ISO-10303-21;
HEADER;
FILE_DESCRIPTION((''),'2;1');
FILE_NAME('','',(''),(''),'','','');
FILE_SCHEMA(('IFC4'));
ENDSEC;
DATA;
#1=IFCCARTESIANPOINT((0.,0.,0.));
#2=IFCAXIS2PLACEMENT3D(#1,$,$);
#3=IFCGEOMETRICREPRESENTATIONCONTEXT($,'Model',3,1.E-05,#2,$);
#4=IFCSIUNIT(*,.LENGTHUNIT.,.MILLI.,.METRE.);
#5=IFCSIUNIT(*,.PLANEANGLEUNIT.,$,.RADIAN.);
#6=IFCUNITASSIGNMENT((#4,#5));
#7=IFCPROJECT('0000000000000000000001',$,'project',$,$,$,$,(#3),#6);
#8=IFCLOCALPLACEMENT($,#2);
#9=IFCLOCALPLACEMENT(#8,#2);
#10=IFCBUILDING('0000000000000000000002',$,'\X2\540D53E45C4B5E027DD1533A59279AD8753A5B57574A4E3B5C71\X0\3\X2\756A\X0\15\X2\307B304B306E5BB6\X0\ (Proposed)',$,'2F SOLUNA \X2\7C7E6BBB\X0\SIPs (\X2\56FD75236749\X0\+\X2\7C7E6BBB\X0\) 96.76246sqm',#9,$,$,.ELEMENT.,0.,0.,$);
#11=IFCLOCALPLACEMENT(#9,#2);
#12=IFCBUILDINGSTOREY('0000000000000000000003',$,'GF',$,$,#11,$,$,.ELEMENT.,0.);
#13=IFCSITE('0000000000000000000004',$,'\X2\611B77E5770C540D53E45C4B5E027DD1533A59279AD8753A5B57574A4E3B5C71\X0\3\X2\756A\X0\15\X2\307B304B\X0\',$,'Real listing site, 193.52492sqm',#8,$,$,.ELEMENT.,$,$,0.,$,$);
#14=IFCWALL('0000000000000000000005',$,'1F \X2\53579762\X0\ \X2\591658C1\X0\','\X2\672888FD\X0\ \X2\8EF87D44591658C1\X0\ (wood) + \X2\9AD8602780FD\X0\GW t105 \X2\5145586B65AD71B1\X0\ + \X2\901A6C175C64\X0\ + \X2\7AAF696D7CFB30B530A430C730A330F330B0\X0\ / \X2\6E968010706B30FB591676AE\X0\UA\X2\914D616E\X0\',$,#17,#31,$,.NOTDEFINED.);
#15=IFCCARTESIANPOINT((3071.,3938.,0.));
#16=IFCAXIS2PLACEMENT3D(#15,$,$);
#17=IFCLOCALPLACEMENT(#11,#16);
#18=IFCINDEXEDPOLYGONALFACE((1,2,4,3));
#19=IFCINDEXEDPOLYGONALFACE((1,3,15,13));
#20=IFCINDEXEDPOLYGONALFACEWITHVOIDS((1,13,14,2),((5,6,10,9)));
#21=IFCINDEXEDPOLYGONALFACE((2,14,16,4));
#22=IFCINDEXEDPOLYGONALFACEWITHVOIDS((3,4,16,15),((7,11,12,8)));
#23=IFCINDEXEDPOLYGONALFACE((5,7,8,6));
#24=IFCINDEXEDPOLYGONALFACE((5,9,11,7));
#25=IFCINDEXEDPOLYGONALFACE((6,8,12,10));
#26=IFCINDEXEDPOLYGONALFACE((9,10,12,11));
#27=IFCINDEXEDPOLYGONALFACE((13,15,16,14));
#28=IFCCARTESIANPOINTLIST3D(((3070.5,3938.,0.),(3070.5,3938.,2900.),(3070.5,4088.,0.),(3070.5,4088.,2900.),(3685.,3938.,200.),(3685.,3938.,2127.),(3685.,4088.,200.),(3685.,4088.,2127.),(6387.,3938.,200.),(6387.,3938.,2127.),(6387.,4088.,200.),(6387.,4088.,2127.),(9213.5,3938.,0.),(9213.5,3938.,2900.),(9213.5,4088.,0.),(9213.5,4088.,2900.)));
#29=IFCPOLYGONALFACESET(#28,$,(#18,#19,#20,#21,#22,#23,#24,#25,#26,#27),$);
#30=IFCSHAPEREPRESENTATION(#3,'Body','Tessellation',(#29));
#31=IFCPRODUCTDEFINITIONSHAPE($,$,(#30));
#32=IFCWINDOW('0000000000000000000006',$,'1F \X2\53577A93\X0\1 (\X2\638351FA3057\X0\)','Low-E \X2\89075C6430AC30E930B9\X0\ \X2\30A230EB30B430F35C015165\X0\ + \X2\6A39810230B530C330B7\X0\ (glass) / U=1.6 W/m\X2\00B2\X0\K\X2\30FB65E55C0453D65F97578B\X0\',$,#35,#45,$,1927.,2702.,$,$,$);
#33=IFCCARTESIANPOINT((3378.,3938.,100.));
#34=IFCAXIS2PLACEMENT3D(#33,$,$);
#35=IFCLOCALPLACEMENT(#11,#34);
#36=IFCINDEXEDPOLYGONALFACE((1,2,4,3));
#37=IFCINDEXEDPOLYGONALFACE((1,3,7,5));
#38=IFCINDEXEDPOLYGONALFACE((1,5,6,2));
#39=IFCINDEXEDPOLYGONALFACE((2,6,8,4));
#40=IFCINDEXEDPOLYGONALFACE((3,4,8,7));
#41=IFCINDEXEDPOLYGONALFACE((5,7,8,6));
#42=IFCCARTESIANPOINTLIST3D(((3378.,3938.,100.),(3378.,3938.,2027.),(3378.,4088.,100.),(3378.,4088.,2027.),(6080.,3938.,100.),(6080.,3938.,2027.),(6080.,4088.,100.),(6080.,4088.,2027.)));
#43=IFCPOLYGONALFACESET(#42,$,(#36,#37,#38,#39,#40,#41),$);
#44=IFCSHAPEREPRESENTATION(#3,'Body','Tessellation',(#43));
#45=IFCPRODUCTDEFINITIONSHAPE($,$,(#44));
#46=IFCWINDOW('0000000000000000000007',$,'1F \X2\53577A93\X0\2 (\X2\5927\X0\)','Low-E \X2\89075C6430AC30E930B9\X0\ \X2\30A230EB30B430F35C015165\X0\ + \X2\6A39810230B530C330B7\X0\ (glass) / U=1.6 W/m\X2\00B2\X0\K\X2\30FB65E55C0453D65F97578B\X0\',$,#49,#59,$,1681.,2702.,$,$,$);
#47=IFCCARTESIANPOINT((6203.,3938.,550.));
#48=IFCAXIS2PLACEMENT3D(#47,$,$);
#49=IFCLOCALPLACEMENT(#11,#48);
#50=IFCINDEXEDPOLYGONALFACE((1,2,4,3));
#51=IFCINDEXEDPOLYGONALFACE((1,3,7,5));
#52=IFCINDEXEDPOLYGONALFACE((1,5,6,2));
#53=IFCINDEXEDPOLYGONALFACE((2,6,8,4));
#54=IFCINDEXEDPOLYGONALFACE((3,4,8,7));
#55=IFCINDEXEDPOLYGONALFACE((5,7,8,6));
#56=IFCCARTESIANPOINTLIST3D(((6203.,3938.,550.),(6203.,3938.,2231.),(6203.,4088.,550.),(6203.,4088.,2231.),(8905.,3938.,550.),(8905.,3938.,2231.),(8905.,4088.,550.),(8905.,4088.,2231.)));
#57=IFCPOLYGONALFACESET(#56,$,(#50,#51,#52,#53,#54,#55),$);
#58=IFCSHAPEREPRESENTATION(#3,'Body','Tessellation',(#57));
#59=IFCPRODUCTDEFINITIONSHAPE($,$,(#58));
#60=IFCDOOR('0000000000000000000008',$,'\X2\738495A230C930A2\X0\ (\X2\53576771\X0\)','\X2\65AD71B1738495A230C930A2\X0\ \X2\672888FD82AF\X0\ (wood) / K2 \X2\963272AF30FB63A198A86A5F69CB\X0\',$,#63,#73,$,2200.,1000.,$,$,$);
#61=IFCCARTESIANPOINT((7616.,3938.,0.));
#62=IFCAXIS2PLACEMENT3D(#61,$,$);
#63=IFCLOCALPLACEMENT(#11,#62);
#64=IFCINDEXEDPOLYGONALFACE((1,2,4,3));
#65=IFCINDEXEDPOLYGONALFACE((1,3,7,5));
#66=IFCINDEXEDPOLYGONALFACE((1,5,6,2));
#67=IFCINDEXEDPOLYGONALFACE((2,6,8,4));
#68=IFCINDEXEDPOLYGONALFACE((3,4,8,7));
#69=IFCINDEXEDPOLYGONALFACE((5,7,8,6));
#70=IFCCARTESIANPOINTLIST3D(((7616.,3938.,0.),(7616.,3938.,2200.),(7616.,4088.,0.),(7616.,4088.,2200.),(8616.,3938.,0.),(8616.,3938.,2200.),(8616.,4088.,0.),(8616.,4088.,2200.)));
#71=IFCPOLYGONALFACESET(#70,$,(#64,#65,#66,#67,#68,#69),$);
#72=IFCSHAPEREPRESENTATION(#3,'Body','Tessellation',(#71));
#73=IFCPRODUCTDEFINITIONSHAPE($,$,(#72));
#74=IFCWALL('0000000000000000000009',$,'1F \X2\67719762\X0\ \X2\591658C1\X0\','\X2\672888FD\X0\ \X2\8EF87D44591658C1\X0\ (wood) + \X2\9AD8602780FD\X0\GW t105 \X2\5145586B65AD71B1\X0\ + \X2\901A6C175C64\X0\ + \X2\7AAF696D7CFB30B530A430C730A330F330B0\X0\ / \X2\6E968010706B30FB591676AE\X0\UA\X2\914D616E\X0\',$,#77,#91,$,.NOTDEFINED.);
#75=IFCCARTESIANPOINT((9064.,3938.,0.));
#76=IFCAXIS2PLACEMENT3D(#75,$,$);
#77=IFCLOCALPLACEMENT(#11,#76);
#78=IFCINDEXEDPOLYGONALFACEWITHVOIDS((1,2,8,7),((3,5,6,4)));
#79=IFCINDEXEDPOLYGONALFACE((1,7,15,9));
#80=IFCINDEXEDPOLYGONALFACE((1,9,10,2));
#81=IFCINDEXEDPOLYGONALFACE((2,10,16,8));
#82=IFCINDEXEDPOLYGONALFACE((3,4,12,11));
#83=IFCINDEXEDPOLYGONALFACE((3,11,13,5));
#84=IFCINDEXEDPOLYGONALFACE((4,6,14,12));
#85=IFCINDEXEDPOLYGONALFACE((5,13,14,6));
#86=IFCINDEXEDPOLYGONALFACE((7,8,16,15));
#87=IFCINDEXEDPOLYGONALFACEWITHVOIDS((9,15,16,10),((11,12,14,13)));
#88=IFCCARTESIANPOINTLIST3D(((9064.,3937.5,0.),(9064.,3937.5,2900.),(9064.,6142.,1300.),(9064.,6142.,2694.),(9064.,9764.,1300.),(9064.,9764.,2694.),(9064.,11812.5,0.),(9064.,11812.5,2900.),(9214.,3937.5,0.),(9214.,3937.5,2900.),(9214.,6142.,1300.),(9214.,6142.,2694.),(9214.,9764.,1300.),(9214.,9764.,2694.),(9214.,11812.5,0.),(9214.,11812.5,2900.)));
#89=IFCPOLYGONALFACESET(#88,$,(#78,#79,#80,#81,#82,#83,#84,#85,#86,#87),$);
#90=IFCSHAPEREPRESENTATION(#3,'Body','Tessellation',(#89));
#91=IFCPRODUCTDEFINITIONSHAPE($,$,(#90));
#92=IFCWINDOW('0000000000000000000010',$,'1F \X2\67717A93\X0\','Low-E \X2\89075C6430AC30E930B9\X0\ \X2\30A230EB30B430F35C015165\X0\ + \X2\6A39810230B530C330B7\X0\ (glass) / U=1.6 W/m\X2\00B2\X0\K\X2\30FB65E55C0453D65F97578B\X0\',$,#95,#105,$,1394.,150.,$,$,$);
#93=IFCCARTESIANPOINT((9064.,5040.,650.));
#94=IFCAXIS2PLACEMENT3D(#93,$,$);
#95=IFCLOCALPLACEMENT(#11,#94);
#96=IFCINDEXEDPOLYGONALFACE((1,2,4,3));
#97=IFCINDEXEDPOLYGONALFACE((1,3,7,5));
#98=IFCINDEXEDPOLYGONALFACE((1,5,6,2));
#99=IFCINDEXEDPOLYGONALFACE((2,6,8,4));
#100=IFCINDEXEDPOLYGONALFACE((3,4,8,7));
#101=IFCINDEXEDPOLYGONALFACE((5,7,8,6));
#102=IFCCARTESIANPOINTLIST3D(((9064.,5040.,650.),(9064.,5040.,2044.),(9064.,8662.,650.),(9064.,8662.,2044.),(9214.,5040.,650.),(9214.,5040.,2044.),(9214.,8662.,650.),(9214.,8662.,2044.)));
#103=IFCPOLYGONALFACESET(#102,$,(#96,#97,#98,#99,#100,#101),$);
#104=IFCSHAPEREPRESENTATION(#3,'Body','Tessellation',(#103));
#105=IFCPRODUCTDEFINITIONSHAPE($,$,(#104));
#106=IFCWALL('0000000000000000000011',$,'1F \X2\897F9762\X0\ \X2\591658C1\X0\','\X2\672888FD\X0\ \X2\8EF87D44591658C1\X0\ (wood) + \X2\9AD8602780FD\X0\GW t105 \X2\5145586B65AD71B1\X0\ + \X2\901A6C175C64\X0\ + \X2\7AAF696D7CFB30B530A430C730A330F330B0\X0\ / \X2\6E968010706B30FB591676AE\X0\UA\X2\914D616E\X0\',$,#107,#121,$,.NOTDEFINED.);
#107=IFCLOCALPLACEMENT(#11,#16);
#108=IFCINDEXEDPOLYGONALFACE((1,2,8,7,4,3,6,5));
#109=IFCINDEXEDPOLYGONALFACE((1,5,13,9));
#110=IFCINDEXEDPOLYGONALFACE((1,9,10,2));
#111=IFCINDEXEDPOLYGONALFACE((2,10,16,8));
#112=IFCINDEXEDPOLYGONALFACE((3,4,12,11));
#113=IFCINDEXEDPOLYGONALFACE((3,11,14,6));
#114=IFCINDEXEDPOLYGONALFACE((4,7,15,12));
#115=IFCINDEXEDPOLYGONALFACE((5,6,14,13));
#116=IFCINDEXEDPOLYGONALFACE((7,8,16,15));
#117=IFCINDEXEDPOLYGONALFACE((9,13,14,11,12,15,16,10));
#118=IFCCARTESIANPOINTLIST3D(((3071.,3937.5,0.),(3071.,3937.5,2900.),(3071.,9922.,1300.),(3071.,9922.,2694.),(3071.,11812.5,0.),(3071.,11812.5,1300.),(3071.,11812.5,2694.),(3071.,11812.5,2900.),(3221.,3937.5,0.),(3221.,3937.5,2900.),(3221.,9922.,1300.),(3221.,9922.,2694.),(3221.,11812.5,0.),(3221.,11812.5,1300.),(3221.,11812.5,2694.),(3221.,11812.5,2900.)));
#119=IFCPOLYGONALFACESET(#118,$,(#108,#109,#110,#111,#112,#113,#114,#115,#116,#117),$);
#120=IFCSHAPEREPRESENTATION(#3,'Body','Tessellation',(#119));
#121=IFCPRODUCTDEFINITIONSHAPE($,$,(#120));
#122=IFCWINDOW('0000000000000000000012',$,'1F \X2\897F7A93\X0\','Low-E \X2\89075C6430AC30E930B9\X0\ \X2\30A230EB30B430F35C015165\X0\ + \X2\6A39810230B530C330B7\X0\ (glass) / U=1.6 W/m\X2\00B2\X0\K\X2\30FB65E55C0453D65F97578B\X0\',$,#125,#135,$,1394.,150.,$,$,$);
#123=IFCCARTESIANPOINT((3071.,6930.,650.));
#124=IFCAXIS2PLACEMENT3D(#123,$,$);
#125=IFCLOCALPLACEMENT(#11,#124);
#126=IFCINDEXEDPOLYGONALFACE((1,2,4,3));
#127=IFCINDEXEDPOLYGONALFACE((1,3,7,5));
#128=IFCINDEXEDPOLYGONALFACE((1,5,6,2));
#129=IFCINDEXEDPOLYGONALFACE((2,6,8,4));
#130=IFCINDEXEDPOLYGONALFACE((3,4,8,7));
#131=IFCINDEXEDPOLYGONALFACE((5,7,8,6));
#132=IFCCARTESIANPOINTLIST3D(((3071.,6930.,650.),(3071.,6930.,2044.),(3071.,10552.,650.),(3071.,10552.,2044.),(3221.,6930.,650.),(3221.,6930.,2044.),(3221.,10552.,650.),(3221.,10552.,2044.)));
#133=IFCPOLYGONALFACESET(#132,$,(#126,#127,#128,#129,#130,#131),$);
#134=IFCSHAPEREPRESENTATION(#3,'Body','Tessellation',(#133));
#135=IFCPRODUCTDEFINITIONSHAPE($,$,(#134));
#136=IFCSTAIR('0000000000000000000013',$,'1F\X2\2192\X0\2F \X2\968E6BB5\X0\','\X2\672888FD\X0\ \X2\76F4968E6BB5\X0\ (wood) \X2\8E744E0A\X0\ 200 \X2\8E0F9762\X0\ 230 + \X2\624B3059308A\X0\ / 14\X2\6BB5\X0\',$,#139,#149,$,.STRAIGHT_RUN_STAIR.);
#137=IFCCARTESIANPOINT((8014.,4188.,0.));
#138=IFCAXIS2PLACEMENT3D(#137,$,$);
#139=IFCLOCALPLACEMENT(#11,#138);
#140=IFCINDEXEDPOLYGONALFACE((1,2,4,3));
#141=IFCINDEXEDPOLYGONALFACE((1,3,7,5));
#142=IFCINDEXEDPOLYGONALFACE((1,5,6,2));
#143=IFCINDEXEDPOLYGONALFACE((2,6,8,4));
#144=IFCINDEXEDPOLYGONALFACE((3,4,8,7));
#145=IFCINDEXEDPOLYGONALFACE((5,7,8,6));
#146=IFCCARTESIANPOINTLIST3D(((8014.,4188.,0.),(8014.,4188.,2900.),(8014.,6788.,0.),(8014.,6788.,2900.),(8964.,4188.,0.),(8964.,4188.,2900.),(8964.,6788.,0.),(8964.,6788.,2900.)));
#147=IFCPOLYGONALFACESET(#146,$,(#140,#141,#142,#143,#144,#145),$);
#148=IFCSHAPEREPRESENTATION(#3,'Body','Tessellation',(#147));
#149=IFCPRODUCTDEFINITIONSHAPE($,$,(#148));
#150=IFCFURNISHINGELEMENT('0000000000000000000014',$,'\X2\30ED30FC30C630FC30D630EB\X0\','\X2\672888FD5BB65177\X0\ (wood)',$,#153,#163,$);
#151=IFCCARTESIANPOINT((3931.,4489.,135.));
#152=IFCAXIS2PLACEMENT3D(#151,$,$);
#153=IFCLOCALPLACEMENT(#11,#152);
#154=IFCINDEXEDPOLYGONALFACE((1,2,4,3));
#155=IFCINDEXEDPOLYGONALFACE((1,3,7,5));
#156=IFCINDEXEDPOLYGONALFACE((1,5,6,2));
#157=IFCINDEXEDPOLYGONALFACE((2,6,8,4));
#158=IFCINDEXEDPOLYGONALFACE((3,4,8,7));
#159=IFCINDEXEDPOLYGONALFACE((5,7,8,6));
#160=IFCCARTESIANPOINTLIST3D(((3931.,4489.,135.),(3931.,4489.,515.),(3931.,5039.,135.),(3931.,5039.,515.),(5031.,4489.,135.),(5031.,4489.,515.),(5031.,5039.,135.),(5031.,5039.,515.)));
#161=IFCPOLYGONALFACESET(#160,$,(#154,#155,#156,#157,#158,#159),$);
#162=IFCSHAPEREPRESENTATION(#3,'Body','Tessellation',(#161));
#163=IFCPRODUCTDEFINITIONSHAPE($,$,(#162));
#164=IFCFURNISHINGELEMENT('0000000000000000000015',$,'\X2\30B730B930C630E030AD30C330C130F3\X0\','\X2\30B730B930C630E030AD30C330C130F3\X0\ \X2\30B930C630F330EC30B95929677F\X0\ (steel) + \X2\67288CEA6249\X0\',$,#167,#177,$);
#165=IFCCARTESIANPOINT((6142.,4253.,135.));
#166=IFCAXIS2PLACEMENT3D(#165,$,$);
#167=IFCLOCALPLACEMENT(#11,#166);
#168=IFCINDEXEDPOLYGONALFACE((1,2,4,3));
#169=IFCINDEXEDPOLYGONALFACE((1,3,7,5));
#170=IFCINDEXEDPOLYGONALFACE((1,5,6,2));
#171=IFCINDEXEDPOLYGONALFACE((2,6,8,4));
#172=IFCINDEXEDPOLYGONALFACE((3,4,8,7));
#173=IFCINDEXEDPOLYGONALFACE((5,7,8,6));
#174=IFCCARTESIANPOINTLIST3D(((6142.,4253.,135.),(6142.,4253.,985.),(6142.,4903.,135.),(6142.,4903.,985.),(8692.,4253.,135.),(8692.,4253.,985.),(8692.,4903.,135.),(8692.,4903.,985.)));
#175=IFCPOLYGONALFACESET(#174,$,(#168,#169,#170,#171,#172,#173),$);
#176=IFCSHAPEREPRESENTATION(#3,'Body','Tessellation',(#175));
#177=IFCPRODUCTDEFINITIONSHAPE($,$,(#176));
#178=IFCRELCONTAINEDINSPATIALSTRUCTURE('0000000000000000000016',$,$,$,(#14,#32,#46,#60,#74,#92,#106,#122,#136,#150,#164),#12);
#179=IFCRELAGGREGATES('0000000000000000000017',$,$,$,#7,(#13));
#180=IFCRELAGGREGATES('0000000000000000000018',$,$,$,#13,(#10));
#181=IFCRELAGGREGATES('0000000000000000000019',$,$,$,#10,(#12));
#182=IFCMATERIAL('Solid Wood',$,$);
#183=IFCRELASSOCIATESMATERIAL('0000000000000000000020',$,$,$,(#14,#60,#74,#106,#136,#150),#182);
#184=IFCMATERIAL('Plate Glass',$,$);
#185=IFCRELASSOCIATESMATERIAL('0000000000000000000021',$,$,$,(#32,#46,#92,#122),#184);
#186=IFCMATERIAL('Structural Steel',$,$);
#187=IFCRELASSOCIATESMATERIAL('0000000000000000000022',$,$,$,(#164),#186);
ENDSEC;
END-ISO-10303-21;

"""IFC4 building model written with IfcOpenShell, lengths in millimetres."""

from ifc_helpers import new_model, si_unit, frame, frame_2d, origin, place, context, project, spatial, rectangle, extrude, material, element, fill, save


model = new_model("IFC4")

# Units and contexts
model_context = context("Model", 3, precision=1e-05, world=origin())
ifc_project = project(units=[si_unit("LENGTHUNIT", "METRE", prefix="MILLI"), si_unit("PLANEANGLEUNIT", "RADIAN")], contexts=[model_context])

# Site, building, storey
site_placement = place(None, origin())
site = spatial("IfcSite", under=ifc_project, at=site_placement, Name="愛知県名古屋市緑区大高町字坊主山3番15ほか", ObjectType="Real listing site, 193.52492sqm", CompositionType="ELEMENT", RefElevation=0.0)
building_placement = place(site_placement, origin())
building = spatial("IfcBuilding", under=site, at=building_placement, Name="名古屋市緑区大高町字坊主山3番15ほかの家 (Proposed)", ObjectType="2F SOLUNA 籾殻SIPs (国産杉+籾殻) 96.76246sqm", CompositionType="ELEMENT", ElevationOfRefHeight=0.0, ElevationOfTerrain=0.0)
storey_placement = place(building_placement, origin())
storey = spatial("IfcBuildingStorey", under=building, at=storey_placement, Name="GF", CompositionType="ELEMENT", Elevation=0.0)

# Shared definitions
ifc_material_1 = material(Name="Solid Wood")

# Wall, openings, windows, door
wall_1_placement = place(storey_placement, frame((3071.0, 3938.0, 0.0)))
wall_1 = element("IfcWall", 1, at=wall_1_placement, inside=storey, material=ifc_material_1, Name="1F 南面 外壁", Description="木製 軸組外壁 (wood) + 高性能GW t105 充填断熱 + 通気層 + 窯業系サイディング / 準耐火・外皮UA配慮", PredefinedType="NOTDEFINED", context=model_context, shape_type="SweptSolid", body=[
    extrude(rectangle(XDim=6143.0, YDim=150.0, at=frame_2d((3071.0, 75.0))), frame((3071.0, 3938.0, 0.0)), (0.0, 0.0, 1.0), 2900.0),
])
opening_1_placement = place(storey_placement, frame((3378.0, 3938.0, 100.0)))
opening_1 = element("IfcOpeningElement", 2, at=opening_1_placement, cuts=wall_1, PredefinedType="NOTDEFINED", context=model_context, shape_type="SweptSolid", body=[
    extrude(rectangle(XDim=2702.0, YDim=150.0, at=frame_2d((1351.0, 75.0))), frame((3378.0, 3938.0, 100.0)), (0.0, 0.0, 1.0), 1927.0),
])
opening_2_placement = place(storey_placement, frame((6203.0, 3938.0, 550.0)))
opening_2 = element("IfcOpeningElement", 3, at=opening_2_placement, cuts=wall_1, PredefinedType="NOTDEFINED", context=model_context, shape_type="SweptSolid", body=[
    extrude(rectangle(XDim=2702.0, YDim=150.0, at=frame_2d((1351.0, 75.0))), frame((6203.0, 3938.0, 550.0)), (0.0, 0.0, 1.0), 1681.0),
])
opening_3_placement = place(storey_placement, frame((7616.0, 3938.0, 0.0)))
opening_3 = element("IfcOpeningElement", 4, at=opening_3_placement, cuts=wall_1, PredefinedType="NOTDEFINED", context=model_context, shape_type="SweptSolid", body=[
    extrude(rectangle(XDim=1000.0, YDim=150.0, at=frame_2d((500.0, 75.0))), frame((7616.0, 3938.0, 0.0)), (0.0, 0.0, 1.0), 2200.0),
])
ifc_material_2 = material(Name="Plate Glass")
window_1_placement = place(storey_placement, frame((3378.0, 3938.0, 100.0)))
window_1 = element("IfcWindow", 5, at=window_1_placement, inside=storey, material=ifc_material_2, Name="1F 南窓1 (掃出し)", Description="Low-E 複層ガラス アルゴン封入 + 樹脂サッシ (glass) / U=1.6 W/m²K・日射取得型", OverallHeight=1927.0, OverallWidth=2702.0, context=model_context, shape_type="SweptSolid", body=[
    extrude(rectangle(XDim=2702.0, YDim=150.0, at=frame_2d((1351.0, 75.0))), frame((3378.0, 3938.0, 100.0)), (0.0, 0.0, 1.0), 1927.0),
])
fill(opening_1, window_1)
window_2_placement = place(storey_placement, frame((6203.0, 3938.0, 550.0)))
window_2 = element("IfcWindow", 6, at=window_2_placement, inside=storey, material=ifc_material_2, Name="1F 南窓2 (大)", Description="Low-E 複層ガラス アルゴン封入 + 樹脂サッシ (glass) / U=1.6 W/m²K・日射取得型", OverallHeight=1681.0, OverallWidth=2702.0, context=model_context, shape_type="SweptSolid", body=[
    extrude(rectangle(XDim=2702.0, YDim=150.0, at=frame_2d((1351.0, 75.0))), frame((6203.0, 3938.0, 550.0)), (0.0, 0.0, 1.0), 1681.0),
])
fill(opening_2, window_2)
door_placement = place(storey_placement, frame((7616.0, 3938.0, 0.0)))
door = element("IfcDoor", 7, at=door_placement, inside=storey, material=ifc_material_1, Name="玄関ドア (南東)", Description="断熱玄関ドア 木製芯 (wood) / K2 防犯・採風機構", OverallHeight=2200.0, OverallWidth=1000.0, context=model_context, shape_type="SweptSolid", body=[
    extrude(rectangle(XDim=1000.0, YDim=150.0, at=frame_2d((500.0, 75.0))), frame((7616.0, 3938.0, 0.0)), (0.0, 0.0, 1.0), 2200.0),
])
fill(opening_3, door)

# Walls, openings, windows
wall_2_placement = place(storey_placement, frame((9064.0, 3938.0, 0.0)))
wall_2 = element("IfcWall", 8, at=wall_2_placement, inside=storey, material=ifc_material_1, Name="1F 東面 外壁", Description="木製 軸組外壁 (wood) + 高性能GW t105 充填断熱 + 通気層 + 窯業系サイディング / 準耐火・外皮UA配慮", PredefinedType="NOTDEFINED", context=model_context, shape_type="SweptSolid", body=[
    extrude(rectangle(XDim=150.0, YDim=7875.0, at=frame_2d((75.0, 3937.0))), frame((9064.0, 3938.0, 0.0)), (0.0, 0.0, 1.0), 2900.0),
])
opening_4_placement = place(storey_placement, frame((9064.0, 5040.0, 650.0)))
opening_4 = element("IfcOpeningElement", 9, at=opening_4_placement, cuts=wall_2, PredefinedType="NOTDEFINED", context=model_context, shape_type="SweptSolid", body=[
    extrude(rectangle(XDim=150.0, YDim=3622.0, at=frame_2d((75.0, 1811.0))), frame((9064.0, 5040.0, 650.0)), (0.0, 0.0, 1.0), 1394.0),
])
window_3_placement = place(storey_placement, frame((9064.0, 5040.0, 650.0)))
window_3 = element("IfcWindow", 10, at=window_3_placement, inside=storey, material=ifc_material_2, Name="1F 東窓", Description="Low-E 複層ガラス アルゴン封入 + 樹脂サッシ (glass) / U=1.6 W/m²K・日射取得型", OverallHeight=1394.0, OverallWidth=150.0, context=model_context, shape_type="SweptSolid", body=[
    extrude(rectangle(XDim=150.0, YDim=3622.0, at=frame_2d((75.0, 1811.0))), frame((9064.0, 5040.0, 650.0)), (0.0, 0.0, 1.0), 1394.0),
])
fill(opening_4, window_3)
wall_3_placement = place(storey_placement, frame((3071.0, 3938.0, 0.0)))
wall_3 = element("IfcWall", 11, at=wall_3_placement, inside=storey, material=ifc_material_1, Name="1F 西面 外壁", Description="木製 軸組外壁 (wood) + 高性能GW t105 充填断熱 + 通気層 + 窯業系サイディング / 準耐火・外皮UA配慮", PredefinedType="NOTDEFINED", context=model_context, shape_type="SweptSolid", body=[
    extrude(rectangle(XDim=150.0, YDim=7875.0, at=frame_2d((75.0, 3937.0))), frame((3071.0, 3938.0, 0.0)), (0.0, 0.0, 1.0), 2900.0),
])
opening_5_placement = place(storey_placement, frame((3071.0, 6930.0, 650.0)))
opening_5 = element("IfcOpeningElement", 12, at=opening_5_placement, cuts=wall_3, PredefinedType="NOTDEFINED", context=model_context, shape_type="SweptSolid", body=[
    extrude(rectangle(XDim=150.0, YDim=3622.0, at=frame_2d((75.0, 1811.0))), frame((3071.0, 6930.0, 650.0)), (0.0, 0.0, 1.0), 1394.0),
])
window_4_placement = place(storey_placement, frame((3071.0, 6930.0, 650.0)))
window_4 = element("IfcWindow", 13, at=window_4_placement, inside=storey, material=ifc_material_2, Name="1F 西窓", Description="Low-E 複層ガラス アルゴン封入 + 樹脂サッシ (glass) / U=1.6 W/m²K・日射取得型", OverallHeight=1394.0, OverallWidth=150.0, context=model_context, shape_type="SweptSolid", body=[
    extrude(rectangle(XDim=150.0, YDim=3622.0, at=frame_2d((75.0, 1811.0))), frame((3071.0, 6930.0, 650.0)), (0.0, 0.0, 1.0), 1394.0),
])
fill(opening_5, window_4)

# Stair
stair_placement = place(storey_placement, frame((8014.0, 4188.0, 0.0)))
element("IfcStair", 14, at=stair_placement, inside=storey, material=ifc_material_1, Name="1F→2F 階段", Description="木製 直階段 (wood) 蹴上 200 踏面 230 + 手すり / 14段", PredefinedType="STRAIGHT_RUN_STAIR", context=model_context, shape_type="SweptSolid", body=[
    extrude(rectangle(XDim=950.0, YDim=2600.0, at=frame_2d((475.0, 1300.0))), frame((8014.0, 4188.0, 0.0)), (0.0, 0.0, 1.0), 2900.0),
])

# Furnishing elements
furnishing_1_placement = place(storey_placement, frame((3931.0, 4489.0, 135.0)))
element("IfcFurnishingElement", 15, at=furnishing_1_placement, inside=storey, material=ifc_material_1, Name="ローテーブル", Description="木製家具 (wood)", context=model_context, shape_type="SweptSolid", body=[
    extrude(rectangle(XDim=1100.0, YDim=550.0, at=frame_2d((550.0, 275.0))), frame((3931.0, 4489.0, 135.0)), (0.0, 0.0, 1.0), 380.0),
])
ifc_material_3 = material(Name="Structural Steel")
furnishing_2_placement = place(storey_placement, frame((6142.0, 4253.0, 135.0)))
element("IfcFurnishingElement", 16, at=furnishing_2_placement, inside=storey, material=ifc_material_3, Name="システムキッチン", Description="システムキッチン ステンレス天板 (steel) + 木質扉", context=model_context, shape_type="SweptSolid", body=[
    extrude(rectangle(XDim=2550.0, YDim=650.0, at=frame_2d((1275.0, 325.0))), frame((6142.0, 4253.0, 135.0)), (0.0, 0.0, 1.0), 850.0),
])

save(model, "model.ifc")
